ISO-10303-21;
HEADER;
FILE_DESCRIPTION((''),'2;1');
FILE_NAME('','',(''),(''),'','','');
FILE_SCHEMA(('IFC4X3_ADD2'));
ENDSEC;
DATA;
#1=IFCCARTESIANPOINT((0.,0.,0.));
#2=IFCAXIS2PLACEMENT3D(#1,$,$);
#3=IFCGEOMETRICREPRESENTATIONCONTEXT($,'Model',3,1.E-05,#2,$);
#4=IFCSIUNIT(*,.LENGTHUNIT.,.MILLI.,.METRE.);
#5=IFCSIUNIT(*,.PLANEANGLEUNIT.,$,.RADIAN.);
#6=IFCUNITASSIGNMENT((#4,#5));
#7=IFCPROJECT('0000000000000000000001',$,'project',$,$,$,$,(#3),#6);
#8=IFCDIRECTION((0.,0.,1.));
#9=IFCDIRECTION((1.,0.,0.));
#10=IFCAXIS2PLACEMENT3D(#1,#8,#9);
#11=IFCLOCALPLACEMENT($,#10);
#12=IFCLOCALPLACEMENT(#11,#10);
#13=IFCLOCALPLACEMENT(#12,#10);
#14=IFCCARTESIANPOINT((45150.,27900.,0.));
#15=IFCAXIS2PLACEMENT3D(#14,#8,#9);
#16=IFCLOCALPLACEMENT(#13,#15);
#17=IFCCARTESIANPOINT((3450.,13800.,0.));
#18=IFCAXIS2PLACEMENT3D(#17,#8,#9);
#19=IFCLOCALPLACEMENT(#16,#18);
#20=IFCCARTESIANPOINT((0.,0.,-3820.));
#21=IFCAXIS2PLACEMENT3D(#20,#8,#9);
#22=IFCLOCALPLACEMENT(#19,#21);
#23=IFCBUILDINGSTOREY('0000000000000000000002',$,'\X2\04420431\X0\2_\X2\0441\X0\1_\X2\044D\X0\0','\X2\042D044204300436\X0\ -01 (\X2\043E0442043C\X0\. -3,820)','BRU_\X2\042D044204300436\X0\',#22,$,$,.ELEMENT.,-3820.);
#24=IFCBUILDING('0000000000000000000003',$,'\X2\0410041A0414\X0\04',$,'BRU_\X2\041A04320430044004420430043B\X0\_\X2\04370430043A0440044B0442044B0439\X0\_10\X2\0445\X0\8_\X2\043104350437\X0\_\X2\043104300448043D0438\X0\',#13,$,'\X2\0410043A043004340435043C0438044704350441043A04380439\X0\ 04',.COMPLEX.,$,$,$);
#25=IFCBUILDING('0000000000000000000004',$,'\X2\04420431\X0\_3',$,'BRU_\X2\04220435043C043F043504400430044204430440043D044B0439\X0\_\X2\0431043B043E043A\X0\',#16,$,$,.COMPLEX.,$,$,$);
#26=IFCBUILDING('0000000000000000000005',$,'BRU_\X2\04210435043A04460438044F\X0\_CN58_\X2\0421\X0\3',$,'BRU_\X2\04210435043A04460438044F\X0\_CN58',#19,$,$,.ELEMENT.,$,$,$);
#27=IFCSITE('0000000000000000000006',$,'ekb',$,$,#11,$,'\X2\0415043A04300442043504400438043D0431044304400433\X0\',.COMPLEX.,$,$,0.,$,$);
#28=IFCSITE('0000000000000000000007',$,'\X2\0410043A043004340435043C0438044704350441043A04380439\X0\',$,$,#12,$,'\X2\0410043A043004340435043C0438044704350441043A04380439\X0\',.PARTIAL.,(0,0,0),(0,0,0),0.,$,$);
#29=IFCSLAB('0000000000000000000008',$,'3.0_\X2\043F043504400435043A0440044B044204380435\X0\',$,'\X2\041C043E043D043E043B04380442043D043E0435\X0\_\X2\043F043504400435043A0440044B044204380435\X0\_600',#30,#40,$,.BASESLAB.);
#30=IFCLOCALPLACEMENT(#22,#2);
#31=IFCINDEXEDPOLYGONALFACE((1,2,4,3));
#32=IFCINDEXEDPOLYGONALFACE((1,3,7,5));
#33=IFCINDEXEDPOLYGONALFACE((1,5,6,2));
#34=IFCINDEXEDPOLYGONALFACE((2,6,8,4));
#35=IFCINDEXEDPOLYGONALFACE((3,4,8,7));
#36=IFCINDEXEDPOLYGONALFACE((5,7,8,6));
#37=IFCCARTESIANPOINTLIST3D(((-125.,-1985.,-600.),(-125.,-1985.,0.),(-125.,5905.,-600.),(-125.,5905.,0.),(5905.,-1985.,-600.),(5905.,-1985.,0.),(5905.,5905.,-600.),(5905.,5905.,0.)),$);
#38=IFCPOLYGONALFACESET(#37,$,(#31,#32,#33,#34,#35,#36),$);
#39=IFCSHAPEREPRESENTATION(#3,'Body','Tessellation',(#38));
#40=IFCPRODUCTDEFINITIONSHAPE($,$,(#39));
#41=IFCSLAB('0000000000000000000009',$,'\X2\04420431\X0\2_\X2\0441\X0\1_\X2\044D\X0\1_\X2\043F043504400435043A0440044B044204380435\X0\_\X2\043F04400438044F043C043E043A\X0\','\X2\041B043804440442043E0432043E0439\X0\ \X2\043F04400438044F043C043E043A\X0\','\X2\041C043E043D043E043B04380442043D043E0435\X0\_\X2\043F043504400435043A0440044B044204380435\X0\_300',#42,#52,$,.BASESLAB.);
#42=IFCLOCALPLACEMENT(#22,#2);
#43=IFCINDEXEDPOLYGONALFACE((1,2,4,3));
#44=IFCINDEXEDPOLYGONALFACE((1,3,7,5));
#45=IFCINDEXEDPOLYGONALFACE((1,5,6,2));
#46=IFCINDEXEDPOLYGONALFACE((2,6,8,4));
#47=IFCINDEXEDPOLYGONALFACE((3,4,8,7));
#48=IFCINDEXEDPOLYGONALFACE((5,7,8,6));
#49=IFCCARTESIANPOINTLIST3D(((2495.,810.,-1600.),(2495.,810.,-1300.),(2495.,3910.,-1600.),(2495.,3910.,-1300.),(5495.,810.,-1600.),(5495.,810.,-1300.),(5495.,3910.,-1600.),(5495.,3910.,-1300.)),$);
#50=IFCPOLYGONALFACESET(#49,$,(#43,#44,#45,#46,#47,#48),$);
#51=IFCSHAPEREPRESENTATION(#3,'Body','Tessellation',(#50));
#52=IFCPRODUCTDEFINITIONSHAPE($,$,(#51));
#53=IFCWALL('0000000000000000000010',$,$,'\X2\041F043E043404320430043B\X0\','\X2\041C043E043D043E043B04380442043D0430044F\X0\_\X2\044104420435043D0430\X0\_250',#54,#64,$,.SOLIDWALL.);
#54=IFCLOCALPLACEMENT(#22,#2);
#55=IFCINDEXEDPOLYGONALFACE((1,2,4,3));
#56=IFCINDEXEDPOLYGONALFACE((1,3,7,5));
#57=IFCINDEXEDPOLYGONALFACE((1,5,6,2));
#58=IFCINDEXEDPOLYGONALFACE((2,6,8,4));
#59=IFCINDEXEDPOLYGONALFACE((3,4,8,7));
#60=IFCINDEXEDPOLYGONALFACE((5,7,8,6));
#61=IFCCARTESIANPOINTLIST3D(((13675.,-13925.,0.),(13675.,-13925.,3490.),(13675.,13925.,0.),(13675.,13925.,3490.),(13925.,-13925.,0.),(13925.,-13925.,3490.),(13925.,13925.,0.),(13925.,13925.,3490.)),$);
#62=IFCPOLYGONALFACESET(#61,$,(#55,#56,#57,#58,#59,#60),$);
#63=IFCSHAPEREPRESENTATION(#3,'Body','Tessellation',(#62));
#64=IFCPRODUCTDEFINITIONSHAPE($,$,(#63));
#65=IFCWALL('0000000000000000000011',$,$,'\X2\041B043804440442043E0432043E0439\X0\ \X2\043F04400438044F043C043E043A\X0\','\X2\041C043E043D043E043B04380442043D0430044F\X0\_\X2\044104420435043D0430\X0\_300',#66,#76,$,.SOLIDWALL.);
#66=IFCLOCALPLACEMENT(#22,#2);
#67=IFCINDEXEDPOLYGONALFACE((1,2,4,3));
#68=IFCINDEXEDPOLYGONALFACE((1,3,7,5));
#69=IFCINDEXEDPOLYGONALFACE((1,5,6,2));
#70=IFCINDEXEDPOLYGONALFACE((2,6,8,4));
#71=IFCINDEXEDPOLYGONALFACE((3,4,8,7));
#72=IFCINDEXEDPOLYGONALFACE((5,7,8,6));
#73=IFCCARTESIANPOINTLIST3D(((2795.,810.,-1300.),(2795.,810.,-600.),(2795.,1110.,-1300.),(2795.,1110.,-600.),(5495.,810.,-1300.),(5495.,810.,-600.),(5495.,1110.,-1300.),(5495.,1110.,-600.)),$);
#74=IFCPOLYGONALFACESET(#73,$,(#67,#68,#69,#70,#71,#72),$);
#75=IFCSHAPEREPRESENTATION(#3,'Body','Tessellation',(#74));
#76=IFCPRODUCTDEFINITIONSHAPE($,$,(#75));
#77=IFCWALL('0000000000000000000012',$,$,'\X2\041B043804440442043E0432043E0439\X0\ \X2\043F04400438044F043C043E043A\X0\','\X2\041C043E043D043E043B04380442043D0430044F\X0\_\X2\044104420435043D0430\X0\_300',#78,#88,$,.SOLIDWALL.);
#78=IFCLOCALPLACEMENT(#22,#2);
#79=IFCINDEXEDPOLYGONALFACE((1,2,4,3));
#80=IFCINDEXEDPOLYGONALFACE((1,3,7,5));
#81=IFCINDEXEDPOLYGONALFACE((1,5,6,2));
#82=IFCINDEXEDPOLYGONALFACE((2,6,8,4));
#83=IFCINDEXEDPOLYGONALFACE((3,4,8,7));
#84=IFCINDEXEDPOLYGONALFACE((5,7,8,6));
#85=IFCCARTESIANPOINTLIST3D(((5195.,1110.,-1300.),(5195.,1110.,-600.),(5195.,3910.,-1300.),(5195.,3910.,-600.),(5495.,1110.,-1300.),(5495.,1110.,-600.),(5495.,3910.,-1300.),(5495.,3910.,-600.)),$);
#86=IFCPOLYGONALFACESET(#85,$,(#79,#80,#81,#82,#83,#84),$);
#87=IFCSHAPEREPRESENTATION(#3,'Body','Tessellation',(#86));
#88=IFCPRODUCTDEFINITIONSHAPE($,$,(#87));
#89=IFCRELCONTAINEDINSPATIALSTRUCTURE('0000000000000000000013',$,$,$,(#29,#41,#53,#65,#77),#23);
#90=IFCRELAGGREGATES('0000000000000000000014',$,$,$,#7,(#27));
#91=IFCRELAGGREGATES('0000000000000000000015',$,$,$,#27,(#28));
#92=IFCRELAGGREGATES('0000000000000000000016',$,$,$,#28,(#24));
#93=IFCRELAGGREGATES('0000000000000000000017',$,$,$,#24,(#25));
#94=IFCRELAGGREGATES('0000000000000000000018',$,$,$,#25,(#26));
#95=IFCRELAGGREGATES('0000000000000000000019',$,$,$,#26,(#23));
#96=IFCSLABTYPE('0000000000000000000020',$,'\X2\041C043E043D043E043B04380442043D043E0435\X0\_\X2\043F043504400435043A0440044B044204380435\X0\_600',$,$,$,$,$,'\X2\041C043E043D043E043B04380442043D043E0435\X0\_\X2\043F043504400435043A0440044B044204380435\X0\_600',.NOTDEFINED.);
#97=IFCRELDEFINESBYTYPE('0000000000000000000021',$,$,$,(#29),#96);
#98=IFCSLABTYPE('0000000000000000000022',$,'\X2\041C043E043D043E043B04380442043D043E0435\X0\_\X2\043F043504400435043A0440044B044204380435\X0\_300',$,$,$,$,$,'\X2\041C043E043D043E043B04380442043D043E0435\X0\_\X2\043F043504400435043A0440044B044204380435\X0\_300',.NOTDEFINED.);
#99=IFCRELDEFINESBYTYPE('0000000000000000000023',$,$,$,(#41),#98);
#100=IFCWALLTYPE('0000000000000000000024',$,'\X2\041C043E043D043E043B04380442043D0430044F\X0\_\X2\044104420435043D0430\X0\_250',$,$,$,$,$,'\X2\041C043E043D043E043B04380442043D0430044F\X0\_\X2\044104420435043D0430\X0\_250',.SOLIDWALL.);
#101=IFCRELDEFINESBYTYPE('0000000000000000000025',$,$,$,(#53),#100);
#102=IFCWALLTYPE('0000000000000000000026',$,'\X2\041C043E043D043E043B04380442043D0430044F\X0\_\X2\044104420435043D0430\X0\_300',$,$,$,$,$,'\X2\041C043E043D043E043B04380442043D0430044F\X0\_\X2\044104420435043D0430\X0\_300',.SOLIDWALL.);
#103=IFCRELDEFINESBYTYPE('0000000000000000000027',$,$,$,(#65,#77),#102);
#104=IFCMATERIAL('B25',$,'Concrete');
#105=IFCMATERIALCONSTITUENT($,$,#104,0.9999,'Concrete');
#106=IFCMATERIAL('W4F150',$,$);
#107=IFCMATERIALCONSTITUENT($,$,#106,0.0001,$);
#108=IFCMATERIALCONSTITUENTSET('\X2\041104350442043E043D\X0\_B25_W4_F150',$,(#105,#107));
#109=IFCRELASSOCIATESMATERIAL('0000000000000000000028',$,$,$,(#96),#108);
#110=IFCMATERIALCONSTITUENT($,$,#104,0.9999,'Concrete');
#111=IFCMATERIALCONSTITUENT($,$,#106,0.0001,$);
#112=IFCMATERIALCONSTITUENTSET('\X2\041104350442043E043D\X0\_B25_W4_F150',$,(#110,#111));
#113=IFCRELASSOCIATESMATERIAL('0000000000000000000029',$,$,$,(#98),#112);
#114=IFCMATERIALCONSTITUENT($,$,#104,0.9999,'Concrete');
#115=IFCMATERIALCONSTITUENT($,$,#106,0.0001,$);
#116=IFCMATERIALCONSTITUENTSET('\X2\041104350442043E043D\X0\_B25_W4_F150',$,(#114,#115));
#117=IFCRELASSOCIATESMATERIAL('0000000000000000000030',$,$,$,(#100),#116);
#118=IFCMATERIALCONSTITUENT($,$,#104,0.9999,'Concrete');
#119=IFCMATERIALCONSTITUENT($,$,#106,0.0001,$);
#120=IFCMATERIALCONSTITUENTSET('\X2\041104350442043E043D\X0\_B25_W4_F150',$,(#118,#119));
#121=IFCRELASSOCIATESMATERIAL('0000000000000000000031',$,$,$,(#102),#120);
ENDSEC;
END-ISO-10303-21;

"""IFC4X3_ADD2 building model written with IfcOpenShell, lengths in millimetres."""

from ifc_helpers import new_model, si_unit, frame, origin, origin_with_axes, origin_2d_with_axis, place, context, project, spatial, polyline, rectangle, outline, extrude, material, constituent, constituent_set, type_object, element, save


model = new_model("IFC4X3_ADD2")

# Units and contexts
model_context = context("Model", 3, precision=1e-05, world=origin())
ifc_project = project(units=[si_unit("LENGTHUNIT", "METRE", prefix="MILLI"), si_unit("PLANEANGLEUNIT", "RADIAN")], contexts=[model_context])

# Sites, buildings, storey
site_1_placement = place(None, origin_with_axes())
site_1 = spatial("IfcSite", under=ifc_project, at=site_1_placement, Name="ekb", LongName="Екатеринбург", CompositionType="COMPLEX", RefElevation=0.0)
site_2_placement = place(site_1_placement, origin_with_axes())
site_2 = spatial("IfcSite", under=site_1, at=site_2_placement, Name="Академический", LongName="Академический", CompositionType="PARTIAL", RefLatitude=(0, 0, 0), RefLongitude=(0, 0, 0), RefElevation=0.0)
building_1_placement = place(site_2_placement, origin_with_axes())
building_1 = spatial("IfcBuilding", under=site_2, at=building_1_placement, Name="АКД04", ObjectType="BRU_Квартал_закрытый_10х8_без_башни", LongName="Академический 04", CompositionType="COMPLEX")
building_2_placement = place(building_1_placement, frame((45150.0, 27900.0, 0.0), z_axis=(0.0, 0.0, 1.0), x_axis=(1.0, 0.0, 0.0)))
building_2 = spatial("IfcBuilding", under=building_1, at=building_2_placement, Name="тб_3", ObjectType="BRU_Температурный_блок", CompositionType="COMPLEX")
building_3_placement = place(building_2_placement, frame((3450.0, 13800.0, 0.0), z_axis=(0.0, 0.0, 1.0), x_axis=(1.0, 0.0, 0.0)))
building_3 = spatial("IfcBuilding", under=building_2, at=building_3_placement, Name="BRU_Секция_CN58_С3", ObjectType="BRU_Секция_CN58", CompositionType="ELEMENT")
storey_placement = place(building_3_placement, frame((0.0, 0.0, -3820.0), z_axis=(0.0, 0.0, 1.0), x_axis=(1.0, 0.0, 0.0)))
storey = spatial("IfcBuildingStorey", under=building_3, at=storey_placement, Name="тб2_с1_э0", Description="Этаж -01 (отм. -3,820)", ObjectType="BRU_Этаж", CompositionType="ELEMENT", Elevation=-3820.0)

# Shared definitions
ifc_material_1 = material(Name="B25", Category="Concrete")
ifc_material_2 = material(Name="W4F150")

# Slabs
ifc_constituent_1 = constituent(ifc_material_1, Category="Concrete", fraction=0.9999)
ifc_constituent_2 = constituent(ifc_material_2, fraction=0.0001)
ifc_constituent_set_1 = constituent_set(constituents=[ifc_constituent_1, ifc_constituent_2], Name="Бетон_B25_W4_F150")
slab_type_1 = type_object("IfcSlabType", Name="Монолитное_перекрытие_600", ElementType="Монолитное_перекрытие_600", PredefinedType="NOTDEFINED", material=ifc_constituent_set_1)
slab_1_placement = place(storey_placement, frame((0.0, 0.0, -600.0), z_axis=(0.0, 0.0, 1.0), x_axis=(1.0, 0.0, 0.0)))
element("IfcSlab", 1, at=slab_1_placement, inside=storey, type_object=slab_type_1, Name="3.0_перекрытие", ObjectType="Монолитное_перекрытие_600", PredefinedType="BASESLAB", context=model_context, shape_type="SweptSolid", body=[
    extrude(outline(polyline([(-125.0, -1985.0), (5905.0, -1985.0), (5905.0, 5905.0), (-125.0, 5905.0), (-125.0, -1985.0)])), origin_with_axes(), (0.0, 0.0, 1.0), 600.0),
])
ifc_constituent_3 = constituent(ifc_material_1, Category="Concrete", fraction=0.9999)
ifc_constituent_4 = constituent(ifc_material_2, fraction=0.0001)
ifc_constituent_set_2 = constituent_set(constituents=[ifc_constituent_3, ifc_constituent_4], Name="Бетон_B25_W4_F150")
slab_type_2 = type_object("IfcSlabType", Name="Монолитное_перекрытие_300", ElementType="Монолитное_перекрытие_300", PredefinedType="NOTDEFINED", material=ifc_constituent_set_2)
slab_2_placement = place(storey_placement, frame((3995.0, 2360.0, -1600.0), z_axis=(0.0, 0.0, 1.0), x_axis=(0.0, -1.0, 0.0)))
element("IfcSlab", 2, at=slab_2_placement, inside=storey, type_object=slab_type_2, Name="тб2_с1_э1_перекрытие_приямок", Description="Лифтовой приямок", ObjectType="Монолитное_перекрытие_300", PredefinedType="BASESLAB", context=model_context, shape_type="SweptSolid", body=[
    extrude(outline(polyline([(-1550.0, -1500.0), (-1550.0, 1500.0), (1550.0, 1500.0), (1550.0, -1500.0), (-1550.0, -1500.0)])), origin_with_axes(), (0.0, 0.0, 1.0), 300.0),
])

# Walls
ifc_constituent_5 = constituent(ifc_material_1, Category="Concrete", fraction=0.9999)
ifc_constituent_6 = constituent(ifc_material_2, fraction=0.0001)
ifc_constituent_set_3 = constituent_set(constituents=[ifc_constituent_5, ifc_constituent_6], Name="Бетон_B25_W4_F150")
wall_type_1 = type_object("IfcWallType", Name="Монолитная_стена_250", ElementType="Монолитная_стена_250", PredefinedType="SOLIDWALL", material=ifc_constituent_set_3)
wall_1_placement = place(storey_placement, frame((13800.0, -13925.0, 0.0), z_axis=(0.0, 0.0, 1.0), x_axis=(0.0, 1.0, 0.0)))
element("IfcWall", 3, at=wall_1_placement, inside=storey, type_object=wall_type_1, Description="Подвал", ObjectType="Монолитная_стена_250", PredefinedType="SOLIDWALL", context=model_context, shape_type="SweptSolid", body=[
    extrude(rectangle(XDim=27850.0, YDim=250.0, at=origin_2d_with_axis()), frame((13925.0, 0.0, 0.0), z_axis=(0.0, 0.0, 1.0), x_axis=(1.0, 0.0, 0.0)), (0.0, 0.0, 1.0), 3490.0),
])
ifc_constituent_7 = constituent(ifc_material_1, Category="Concrete", fraction=0.9999)
ifc_constituent_8 = constituent(ifc_material_2, fraction=0.0001)
ifc_constituent_set_4 = constituent_set(constituents=[ifc_constituent_7, ifc_constituent_8], Name="Бетон_B25_W4_F150")
wall_type_2 = type_object("IfcWallType", Name="Монолитная_стена_300", ElementType="Монолитная_стена_300", PredefinedType="SOLIDWALL", material=ifc_constituent_set_4)
wall_2_placement = place(storey_placement, frame((2795.0, 960.0, -1300.0), z_axis=(0.0, 0.0, 1.0), x_axis=(1.0, 0.0, 0.0)))
element("IfcWall", 4, at=wall_2_placement, inside=storey, type_object=wall_type_2, Description="Лифтовой приямок", ObjectType="Монолитная_стена_300", PredefinedType="SOLIDWALL", context=model_context, shape_type="SweptSolid", body=[
    extrude(rectangle(XDim=2700.0, YDim=300.0, at=origin_2d_with_axis()), frame((1350.0, 0.0, 0.0), z_axis=(0.0, 0.0, 1.0), x_axis=(1.0, 0.0, 0.0)), (0.0, 0.0, 1.0), 700.0),
])
wall_3_placement = place(storey_placement, frame((5345.0, 1110.0, -1300.0), z_axis=(0.0, 0.0, 1.0), x_axis=(0.0, 1.0, 0.0)))
element("IfcWall", 5, at=wall_3_placement, inside=storey, type_object=wall_type_2, Description="Лифтовой приямок", ObjectType="Монолитная_стена_300", PredefinedType="SOLIDWALL", context=model_context, shape_type="SweptSolid", body=[
    extrude(rectangle(XDim=2800.0, YDim=300.0, at=origin_2d_with_axis()), frame((1400.0, 0.0, 0.0), z_axis=(0.0, 0.0, 1.0), x_axis=(1.0, 0.0, 0.0)), (0.0, 0.0, 1.0), 700.0),
])

save(model, "model.ifc")
